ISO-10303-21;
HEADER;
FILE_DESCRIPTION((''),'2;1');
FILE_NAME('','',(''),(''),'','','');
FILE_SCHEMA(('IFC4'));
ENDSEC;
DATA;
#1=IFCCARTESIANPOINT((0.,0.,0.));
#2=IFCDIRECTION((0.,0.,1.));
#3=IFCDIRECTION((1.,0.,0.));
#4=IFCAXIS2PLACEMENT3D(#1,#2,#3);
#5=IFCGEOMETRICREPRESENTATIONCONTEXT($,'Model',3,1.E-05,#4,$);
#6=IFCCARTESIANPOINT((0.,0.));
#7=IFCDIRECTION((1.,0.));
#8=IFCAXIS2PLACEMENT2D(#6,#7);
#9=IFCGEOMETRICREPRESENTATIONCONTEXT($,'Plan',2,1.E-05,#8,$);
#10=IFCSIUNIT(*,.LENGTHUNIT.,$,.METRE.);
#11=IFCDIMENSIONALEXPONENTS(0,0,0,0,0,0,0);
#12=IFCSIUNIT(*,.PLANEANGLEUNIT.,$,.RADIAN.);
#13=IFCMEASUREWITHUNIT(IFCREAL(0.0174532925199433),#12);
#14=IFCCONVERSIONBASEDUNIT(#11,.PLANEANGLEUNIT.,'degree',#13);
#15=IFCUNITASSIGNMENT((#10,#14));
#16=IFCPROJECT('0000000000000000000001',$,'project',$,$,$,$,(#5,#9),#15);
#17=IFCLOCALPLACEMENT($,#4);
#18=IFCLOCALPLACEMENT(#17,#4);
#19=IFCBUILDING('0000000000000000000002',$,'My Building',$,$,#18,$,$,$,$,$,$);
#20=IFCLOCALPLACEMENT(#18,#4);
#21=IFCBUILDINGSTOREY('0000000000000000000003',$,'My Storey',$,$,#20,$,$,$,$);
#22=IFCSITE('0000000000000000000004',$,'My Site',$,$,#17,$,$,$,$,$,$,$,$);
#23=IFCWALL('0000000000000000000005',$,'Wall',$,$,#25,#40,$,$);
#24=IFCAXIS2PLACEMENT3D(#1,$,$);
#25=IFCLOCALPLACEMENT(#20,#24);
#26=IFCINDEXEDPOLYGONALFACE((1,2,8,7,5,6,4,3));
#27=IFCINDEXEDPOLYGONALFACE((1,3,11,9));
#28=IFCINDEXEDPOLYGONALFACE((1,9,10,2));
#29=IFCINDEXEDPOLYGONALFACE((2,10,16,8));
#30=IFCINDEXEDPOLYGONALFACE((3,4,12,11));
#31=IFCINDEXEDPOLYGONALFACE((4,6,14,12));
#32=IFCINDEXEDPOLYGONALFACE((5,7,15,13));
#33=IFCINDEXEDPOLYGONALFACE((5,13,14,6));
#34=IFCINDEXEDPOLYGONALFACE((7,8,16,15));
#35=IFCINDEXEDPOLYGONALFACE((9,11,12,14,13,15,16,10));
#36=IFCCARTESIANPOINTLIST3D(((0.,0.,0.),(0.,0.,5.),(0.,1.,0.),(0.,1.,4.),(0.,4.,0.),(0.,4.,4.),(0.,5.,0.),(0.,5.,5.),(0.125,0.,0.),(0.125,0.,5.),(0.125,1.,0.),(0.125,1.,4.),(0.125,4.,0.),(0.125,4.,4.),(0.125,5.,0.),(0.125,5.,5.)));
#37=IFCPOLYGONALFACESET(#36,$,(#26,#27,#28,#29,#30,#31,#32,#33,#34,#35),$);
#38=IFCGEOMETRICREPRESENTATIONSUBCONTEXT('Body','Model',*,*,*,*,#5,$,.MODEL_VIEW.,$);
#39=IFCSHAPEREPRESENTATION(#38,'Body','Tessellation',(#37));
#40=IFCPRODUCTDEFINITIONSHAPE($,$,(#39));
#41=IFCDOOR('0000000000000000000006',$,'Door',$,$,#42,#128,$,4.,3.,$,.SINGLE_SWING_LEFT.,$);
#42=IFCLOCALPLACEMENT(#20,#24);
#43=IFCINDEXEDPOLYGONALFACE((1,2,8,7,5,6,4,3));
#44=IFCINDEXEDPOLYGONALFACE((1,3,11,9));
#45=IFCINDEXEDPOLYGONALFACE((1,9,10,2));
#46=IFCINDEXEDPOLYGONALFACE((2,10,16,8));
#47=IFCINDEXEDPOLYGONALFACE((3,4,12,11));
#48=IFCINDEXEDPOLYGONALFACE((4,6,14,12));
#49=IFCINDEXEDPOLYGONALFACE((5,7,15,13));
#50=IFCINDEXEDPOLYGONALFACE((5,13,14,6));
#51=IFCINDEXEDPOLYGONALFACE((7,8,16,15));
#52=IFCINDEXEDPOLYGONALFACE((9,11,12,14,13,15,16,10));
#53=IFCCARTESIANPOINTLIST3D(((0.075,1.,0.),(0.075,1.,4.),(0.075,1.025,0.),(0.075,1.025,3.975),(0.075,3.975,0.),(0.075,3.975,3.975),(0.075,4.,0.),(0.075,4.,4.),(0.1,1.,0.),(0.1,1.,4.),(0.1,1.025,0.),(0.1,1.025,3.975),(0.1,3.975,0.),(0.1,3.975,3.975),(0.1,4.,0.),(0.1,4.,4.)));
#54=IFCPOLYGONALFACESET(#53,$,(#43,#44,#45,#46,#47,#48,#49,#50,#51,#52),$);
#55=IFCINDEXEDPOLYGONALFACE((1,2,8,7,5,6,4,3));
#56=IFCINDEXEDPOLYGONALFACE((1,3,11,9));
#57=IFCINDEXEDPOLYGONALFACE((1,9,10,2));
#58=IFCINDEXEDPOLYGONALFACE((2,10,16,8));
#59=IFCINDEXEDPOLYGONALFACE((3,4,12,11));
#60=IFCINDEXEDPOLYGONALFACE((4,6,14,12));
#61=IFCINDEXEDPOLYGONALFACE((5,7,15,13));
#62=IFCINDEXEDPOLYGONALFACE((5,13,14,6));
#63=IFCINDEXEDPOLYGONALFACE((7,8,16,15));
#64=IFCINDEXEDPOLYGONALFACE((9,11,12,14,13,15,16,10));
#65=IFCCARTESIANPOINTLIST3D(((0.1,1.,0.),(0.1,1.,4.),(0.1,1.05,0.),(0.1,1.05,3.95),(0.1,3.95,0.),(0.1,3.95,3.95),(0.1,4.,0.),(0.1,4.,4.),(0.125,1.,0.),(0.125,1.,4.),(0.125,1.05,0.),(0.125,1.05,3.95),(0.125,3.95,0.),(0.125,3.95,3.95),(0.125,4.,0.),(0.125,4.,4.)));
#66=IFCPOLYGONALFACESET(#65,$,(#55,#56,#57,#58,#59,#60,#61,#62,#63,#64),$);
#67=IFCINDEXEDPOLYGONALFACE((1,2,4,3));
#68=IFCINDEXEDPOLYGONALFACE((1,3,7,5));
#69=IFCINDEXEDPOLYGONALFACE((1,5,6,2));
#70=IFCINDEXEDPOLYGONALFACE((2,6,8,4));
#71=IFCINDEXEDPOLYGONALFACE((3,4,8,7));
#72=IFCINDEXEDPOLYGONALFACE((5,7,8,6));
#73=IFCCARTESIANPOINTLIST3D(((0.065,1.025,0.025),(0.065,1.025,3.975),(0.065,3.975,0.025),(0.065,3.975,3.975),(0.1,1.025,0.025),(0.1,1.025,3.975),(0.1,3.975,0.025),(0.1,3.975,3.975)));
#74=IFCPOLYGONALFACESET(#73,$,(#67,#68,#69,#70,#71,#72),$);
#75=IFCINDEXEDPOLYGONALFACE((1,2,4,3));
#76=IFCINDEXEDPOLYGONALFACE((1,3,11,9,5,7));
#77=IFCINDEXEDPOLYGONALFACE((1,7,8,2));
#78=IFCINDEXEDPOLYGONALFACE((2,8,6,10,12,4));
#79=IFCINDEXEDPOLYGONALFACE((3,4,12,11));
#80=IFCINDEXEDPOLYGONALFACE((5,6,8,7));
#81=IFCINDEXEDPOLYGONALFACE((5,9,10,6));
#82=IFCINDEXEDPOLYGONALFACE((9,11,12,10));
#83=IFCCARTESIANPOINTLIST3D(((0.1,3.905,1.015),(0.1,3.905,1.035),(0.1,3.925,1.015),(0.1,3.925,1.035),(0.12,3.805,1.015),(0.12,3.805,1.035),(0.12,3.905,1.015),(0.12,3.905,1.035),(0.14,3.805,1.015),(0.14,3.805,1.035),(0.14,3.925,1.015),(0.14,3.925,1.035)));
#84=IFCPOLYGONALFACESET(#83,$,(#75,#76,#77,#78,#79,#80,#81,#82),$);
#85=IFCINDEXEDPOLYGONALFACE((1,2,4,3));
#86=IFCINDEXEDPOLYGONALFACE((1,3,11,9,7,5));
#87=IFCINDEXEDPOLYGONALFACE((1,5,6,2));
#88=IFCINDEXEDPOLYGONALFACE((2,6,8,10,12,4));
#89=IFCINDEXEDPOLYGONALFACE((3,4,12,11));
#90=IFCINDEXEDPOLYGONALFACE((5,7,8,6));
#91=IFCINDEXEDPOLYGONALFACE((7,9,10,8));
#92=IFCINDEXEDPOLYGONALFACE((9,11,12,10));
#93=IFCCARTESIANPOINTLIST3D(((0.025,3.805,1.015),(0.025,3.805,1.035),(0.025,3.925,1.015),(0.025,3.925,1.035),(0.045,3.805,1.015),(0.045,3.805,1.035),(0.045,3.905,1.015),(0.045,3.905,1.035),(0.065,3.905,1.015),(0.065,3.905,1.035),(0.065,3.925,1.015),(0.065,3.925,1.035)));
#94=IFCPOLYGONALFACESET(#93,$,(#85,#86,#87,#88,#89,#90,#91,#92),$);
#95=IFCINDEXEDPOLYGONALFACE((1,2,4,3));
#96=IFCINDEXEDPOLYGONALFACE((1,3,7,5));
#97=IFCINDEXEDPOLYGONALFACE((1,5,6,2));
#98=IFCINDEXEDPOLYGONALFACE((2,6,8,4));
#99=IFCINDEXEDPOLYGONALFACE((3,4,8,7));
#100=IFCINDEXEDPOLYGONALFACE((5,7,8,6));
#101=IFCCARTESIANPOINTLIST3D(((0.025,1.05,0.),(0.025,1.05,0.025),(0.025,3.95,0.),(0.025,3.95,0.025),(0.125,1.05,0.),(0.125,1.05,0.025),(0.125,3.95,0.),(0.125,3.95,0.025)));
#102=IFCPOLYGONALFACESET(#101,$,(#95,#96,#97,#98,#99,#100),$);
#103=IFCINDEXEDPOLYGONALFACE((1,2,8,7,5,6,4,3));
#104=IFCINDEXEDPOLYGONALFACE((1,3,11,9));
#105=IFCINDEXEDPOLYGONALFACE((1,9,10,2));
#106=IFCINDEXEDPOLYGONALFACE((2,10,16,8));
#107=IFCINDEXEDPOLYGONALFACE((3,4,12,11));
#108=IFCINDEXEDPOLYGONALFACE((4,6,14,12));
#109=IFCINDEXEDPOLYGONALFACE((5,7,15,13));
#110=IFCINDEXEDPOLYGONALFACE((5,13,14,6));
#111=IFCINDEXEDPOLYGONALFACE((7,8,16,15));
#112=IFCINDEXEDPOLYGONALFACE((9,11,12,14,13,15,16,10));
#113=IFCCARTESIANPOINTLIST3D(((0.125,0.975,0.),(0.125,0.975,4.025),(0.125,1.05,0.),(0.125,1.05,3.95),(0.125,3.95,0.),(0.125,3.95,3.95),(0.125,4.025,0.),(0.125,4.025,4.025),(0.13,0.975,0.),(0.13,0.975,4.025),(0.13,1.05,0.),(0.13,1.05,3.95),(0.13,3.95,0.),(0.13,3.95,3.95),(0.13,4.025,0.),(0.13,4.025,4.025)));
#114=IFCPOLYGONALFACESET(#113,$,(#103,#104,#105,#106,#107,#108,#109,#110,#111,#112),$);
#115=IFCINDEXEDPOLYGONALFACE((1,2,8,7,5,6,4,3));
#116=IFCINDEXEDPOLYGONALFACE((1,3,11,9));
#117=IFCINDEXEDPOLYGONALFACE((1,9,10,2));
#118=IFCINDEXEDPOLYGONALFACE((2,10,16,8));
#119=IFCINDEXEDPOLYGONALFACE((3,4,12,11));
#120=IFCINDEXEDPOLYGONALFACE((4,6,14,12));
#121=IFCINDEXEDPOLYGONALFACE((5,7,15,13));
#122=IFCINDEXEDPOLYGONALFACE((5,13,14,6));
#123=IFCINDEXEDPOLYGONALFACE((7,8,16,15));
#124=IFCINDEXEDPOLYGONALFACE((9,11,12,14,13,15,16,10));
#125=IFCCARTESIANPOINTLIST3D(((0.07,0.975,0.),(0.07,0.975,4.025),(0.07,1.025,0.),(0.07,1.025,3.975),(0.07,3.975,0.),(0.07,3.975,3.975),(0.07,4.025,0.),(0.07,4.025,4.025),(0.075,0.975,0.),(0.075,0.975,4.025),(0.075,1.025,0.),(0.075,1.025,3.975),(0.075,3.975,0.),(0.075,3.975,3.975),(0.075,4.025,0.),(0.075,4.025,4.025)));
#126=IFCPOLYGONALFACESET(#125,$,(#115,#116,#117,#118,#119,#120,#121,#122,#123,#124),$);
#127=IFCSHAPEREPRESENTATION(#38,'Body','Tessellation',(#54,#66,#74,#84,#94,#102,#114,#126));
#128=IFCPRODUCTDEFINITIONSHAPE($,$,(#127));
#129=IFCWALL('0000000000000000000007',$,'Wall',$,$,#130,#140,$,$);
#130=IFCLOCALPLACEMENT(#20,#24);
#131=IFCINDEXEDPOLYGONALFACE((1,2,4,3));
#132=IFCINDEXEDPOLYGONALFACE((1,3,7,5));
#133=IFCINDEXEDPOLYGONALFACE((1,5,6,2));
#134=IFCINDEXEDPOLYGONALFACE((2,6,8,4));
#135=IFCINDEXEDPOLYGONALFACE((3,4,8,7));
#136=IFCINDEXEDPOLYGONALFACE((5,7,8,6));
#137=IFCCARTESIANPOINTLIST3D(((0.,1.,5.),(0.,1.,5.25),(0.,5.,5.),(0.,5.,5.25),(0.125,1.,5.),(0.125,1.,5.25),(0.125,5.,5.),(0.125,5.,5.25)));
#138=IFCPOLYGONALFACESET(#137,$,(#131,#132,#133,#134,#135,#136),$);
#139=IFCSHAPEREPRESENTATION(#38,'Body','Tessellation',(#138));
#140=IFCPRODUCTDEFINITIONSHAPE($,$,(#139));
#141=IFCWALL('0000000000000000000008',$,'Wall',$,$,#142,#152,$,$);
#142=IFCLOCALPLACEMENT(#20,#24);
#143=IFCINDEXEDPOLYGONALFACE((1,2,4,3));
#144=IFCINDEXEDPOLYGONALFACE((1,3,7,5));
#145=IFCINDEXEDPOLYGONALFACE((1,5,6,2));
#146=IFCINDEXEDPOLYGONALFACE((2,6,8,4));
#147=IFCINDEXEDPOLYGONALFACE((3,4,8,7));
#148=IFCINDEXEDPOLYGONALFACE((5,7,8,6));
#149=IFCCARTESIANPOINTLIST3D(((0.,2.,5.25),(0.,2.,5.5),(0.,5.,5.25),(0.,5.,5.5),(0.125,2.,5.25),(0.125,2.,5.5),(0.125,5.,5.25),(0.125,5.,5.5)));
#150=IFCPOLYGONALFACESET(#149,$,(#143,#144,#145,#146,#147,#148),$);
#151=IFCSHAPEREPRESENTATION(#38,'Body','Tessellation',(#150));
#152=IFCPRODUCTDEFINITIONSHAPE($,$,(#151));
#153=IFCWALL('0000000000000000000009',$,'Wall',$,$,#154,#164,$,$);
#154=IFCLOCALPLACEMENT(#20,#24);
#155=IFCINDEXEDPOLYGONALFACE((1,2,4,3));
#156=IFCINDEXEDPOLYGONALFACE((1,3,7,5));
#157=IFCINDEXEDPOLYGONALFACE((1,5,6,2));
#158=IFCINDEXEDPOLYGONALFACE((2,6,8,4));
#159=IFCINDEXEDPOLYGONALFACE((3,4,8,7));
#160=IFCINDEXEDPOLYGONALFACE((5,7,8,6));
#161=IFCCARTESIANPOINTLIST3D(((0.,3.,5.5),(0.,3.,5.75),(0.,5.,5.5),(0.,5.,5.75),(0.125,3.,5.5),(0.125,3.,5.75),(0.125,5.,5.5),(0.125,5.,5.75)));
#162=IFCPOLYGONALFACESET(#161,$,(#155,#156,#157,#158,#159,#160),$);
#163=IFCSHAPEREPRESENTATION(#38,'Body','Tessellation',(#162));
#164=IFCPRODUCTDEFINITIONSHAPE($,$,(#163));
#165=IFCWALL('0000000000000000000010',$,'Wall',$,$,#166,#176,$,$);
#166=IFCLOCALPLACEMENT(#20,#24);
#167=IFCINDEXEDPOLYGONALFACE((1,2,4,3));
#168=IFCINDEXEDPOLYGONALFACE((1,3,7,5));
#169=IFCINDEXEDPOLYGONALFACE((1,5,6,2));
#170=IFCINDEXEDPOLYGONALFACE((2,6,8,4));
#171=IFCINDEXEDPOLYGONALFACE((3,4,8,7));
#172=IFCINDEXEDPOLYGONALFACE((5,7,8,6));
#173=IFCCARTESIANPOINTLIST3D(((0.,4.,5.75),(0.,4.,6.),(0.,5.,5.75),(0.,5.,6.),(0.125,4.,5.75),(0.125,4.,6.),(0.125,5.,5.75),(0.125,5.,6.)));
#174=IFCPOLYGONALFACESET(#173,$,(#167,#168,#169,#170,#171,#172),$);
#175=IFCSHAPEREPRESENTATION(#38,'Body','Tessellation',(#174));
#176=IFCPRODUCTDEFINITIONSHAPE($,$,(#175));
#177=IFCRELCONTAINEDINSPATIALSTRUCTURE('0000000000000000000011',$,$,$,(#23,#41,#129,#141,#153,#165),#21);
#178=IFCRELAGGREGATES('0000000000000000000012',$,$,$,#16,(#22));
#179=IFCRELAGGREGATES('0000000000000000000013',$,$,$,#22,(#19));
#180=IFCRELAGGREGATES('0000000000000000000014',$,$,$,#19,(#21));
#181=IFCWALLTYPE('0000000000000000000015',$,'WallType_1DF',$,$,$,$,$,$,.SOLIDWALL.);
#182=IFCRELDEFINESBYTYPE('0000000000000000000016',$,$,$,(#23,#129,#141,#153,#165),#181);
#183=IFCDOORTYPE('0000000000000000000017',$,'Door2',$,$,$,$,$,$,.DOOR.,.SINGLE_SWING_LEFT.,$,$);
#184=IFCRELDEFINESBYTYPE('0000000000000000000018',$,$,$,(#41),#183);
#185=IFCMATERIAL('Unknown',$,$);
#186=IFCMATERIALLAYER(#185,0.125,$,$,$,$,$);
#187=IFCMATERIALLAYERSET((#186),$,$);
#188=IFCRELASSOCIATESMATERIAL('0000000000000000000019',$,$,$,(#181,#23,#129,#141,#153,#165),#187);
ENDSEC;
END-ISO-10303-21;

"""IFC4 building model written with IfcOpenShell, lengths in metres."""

from ifc_helpers import new_model, entity, si_unit, converted_unit, frame, origin_with_axes, origin_2d_with_axis, place, context, subcontext, project, spatial, line, indexed_curve, outline, extrude, shape, source, transform, mapped, material, layer, layer_set, layer_usage, type_object, type_shapes, element, fill, save


model = new_model("IFC4")

# Units and contexts
model_context = context("Model", 3, precision=1e-05, world=origin_with_axes())
plan_context = context("Plan", 2, precision=1e-05, world=origin_2d_with_axis())
body_context_1 = subcontext(model_context, "Body", "Model", "MODEL_VIEW")
body_context_2 = subcontext(plan_context, "Body", "Plan", "PLAN_VIEW")
ifc_project = project(units=[si_unit("LENGTHUNIT", "METRE"), converted_unit("PLANEANGLEUNIT", "degree", entity("IfcReal", 0.0174532925199433), si_unit("PLANEANGLEUNIT", "RADIAN"), dimensions=[0, 0, 0, 0, 0, 0, 0])], contexts=[model_context, plan_context])

# Site, building, storey
site_placement = place(None, origin_with_axes())
site = spatial("IfcSite", under=ifc_project, at=site_placement, Name="My Site")
building_placement = place(site_placement, origin_with_axes())
building = spatial("IfcBuilding", under=site, at=building_placement, Name="My Building")
storey_placement = place(building_placement, origin_with_axes())
storey = spatial("IfcBuildingStorey", under=building, at=storey_placement, Name="My Storey")

# Wall, opening, door
ifc_material = material(Name="Unknown")
ifc_layer = layer(ifc_material, 0.125)
ifc_layer_set = layer_set([ifc_layer])
ifc_layer_usage_1 = layer_usage(ifc_layer_set, "AXIS2", "POSITIVE", 0.0)
wall_type = type_object("IfcWallType", Name="WallType_1DF", PredefinedType="SOLIDWALL", material=ifc_layer_set)
wall_1_placement = place(storey_placement, frame((0.125, 0.0, 0.0), z_axis=(0.0, 0.0, 1.0), x_axis=(0.0, 1.0, 0.0)))
wall_1 = element("IfcWall", 1, at=wall_1_placement, inside=storey, type_object=wall_type, material=ifc_layer_usage_1, Name="Wall", context=body_context_1, shape_type="SweptSolid", body=[
    extrude(outline(indexed_curve([(0.0, 0.0), (0.0, 0.125), (5.0, 0.125), (5.0, 0.0), (0.0, 0.0)], self_intersect=False)), origin_with_axes(), (0.0, 0.0, 1.0), 5.0),
])
shared_shape_1 = source(origin_with_axes(), body_context_1, "Body", "SweptSolid", [
    extrude(outline(indexed_curve([(0.0, 0.0), (3.0, 0.0), (3.0, 4.0), (0.0, 4.0)], segments=[line(1, 2, 3, 4, 1)])), frame((0.0, -0.1, 0.0), z_axis=(0.0, -1.0, 0.0), x_axis=(1.0, 0.0, 0.0)), (0.0, 0.0, -1.0), 0.45),
])
opening_1_placement = place(wall_1_placement, frame((1.0, 0.0, 0.0), z_axis=(0.0, 0.0, 1.0), x_axis=(1.0, 0.0, 0.0)))
opening_1 = element("IfcOpeningElement", 2, at=opening_1_placement, cuts=wall_1, PredefinedType="OPENING", context=body_context_1, shape_type="MappedRepresentation", body=[
    mapped(shared_shape_1, transform((0.0, 0.0, 0.0), x_axis=(1.0, 0.0, 0.0), y_axis=(0.0, 1.0, 0.0), z_axis=(0.0, 0.0, 1.0), scale=1.0)),
])
door_type = type_object("IfcDoorType", Name="Door2", OperationType="SINGLE_SWING_LEFT", PredefinedType="DOOR")
shared_shape_2 = source(origin_with_axes(), body_context_1, "Body", "SweptSolid", [
    extrude(outline(indexed_curve([(0.0, 0.0), (0.0, 4.0), (3.0, 4.0), (3.0, 0.0), (2.975, 0.0), (2.975, 3.975), (0.025, 3.975), (0.025, 0.0)], segments=[line(1, 2, 3, 4, 5, 6, 7, 8, 1)])), frame((0.0, 0.025, 0.0), z_axis=(0.0, -1.0, 0.0), x_axis=(1.0, 0.0, 0.0)), (0.0, 0.0, -1.0), 0.025),
    extrude(outline(indexed_curve([(0.0, 0.0), (0.0, 4.0), (3.0, 4.0), (3.0, 0.0), (2.95, 0.0), (2.95, 3.95), (0.05, 3.95), (0.05, 0.0)], segments=[line(1, 2, 3, 4, 5, 6, 7, 8, 1)])), frame((0.0, 0.0, 0.0), z_axis=(0.0, -1.0, 0.0), x_axis=(1.0, 0.0, 0.0)), (0.0, 0.0, -1.0), 0.025),
    extrude(outline(indexed_curve([(0.0, 0.0), (2.95, 0.0), (2.95, 0.035), (0.0, 0.035)], segments=[line(1, 2, 3, 4, 1)])), frame((0.025, 0.025, 0.025), z_axis=(0.0, 0.0, 1.0), x_axis=(1.0, 0.0, 0.0)), (0.0, 0.0, 1.0), 3.95),
    extrude(outline(indexed_curve([(0.0, 0.0), (0.0, -0.04), (-0.12, -0.04), (-0.12, -0.02), (-0.02, -0.02), (-0.02, 0.0)], segments=[line(1, 2, 3, 4, 5, 6, 1)])), frame((2.925, 0.025, 1.015), z_axis=(0.0, 0.0, 1.0), x_axis=(1.0, 0.0, 0.0)), (0.0, 0.0, 1.0), 0.02),
    extrude(outline(indexed_curve([(0.0, 0.0), (0.0, 0.04), (-0.12, 0.04), (-0.12, 0.02), (-0.02, 0.02), (-0.02, 0.0)], segments=[line(1, 2, 3, 4, 5, 6, 1)])), frame((2.925, 0.06, 1.015), z_axis=(0.0, 0.0, 1.0), x_axis=(1.0, 0.0, 0.0)), (0.0, 0.0, 1.0), 0.02),
    extrude(outline(indexed_curve([(0.0, 0.0), (2.9, 0.0), (2.9, 0.1), (0.0, 0.1)], segments=[line(1, 2, 3, 4, 1)])), frame((0.05, 0.0, 0.0), z_axis=(0.0, 0.0, 1.0), x_axis=(1.0, 0.0, 0.0)), (0.0, 0.0, 1.0), 0.025),
    extrude(outline(indexed_curve([(0.0, 0.0), (0.0, 4.025), (3.05, 4.025), (3.05, 0.0), (2.975, 0.0), (2.975, 3.95), (0.075, 3.95), (0.075, 0.0)], segments=[line(1, 2, 3, 4, 5, 6, 7, 8, 1)])), frame((-0.025, -0.005, 0.0), z_axis=(0.0, -1.0, 0.0), x_axis=(1.0, 0.0, 0.0)), (0.0, 0.0, -1.0), 0.005),
    extrude(outline(indexed_curve([(0.0, 0.0), (0.0, 4.025), (3.05, 4.025), (3.05, 0.0), (3.0, 0.0), (3.0, 3.975), (0.05, 3.975), (0.05, 0.0)], segments=[line(1, 2, 3, 4, 5, 6, 7, 8, 1)])), frame((-0.025, 0.05, 0.0), z_axis=(0.0, -1.0, 0.0), x_axis=(1.0, 0.0, 0.0)), (0.0, 0.0, -1.0), 0.005),
])
shared_shape_3 = source(origin_with_axes(), body_context_2, "Body", "Curve2D", [
    entity("IfcIndexedPolyCurve", entity("IfcCartesianPointList2D", [[0.0, 0.0], [0.0, 0.05], [0.025, 0.05], [0.025, 0.025], [0.05, 0.025], [0.05, 0.0]]), [entity("IfcLineIndex", [1, 2, 3, 4, 5, 6, 1])]),
    entity("IfcIndexedPolyCurve", entity("IfcCartesianPointList2D", [[3.0, 0.0], [3.0, 0.05], [2.975, 0.05], [2.975, 0.025], [2.95, 0.025], [2.95, 0.0]]), [entity("IfcLineIndex", [1, 2, 3, 4, 5, 6, 1])]),
    entity("IfcTrimmedCurve", entity("IfcEllipse", entity("IfcAxis2Placement2D", entity("IfcCartesianPoint", [0.06, 0.05]), entity("IfcDirection", [1.0, 0.0])), 2.915, 2.95), [entity("IfcCartesianPoint", [2.975, 0.05])], [entity("IfcCartesianPoint", [0.06, 3.0])], True, "CARTESIAN"),
    entity("IfcIndexedPolyCurve", entity("IfcCartesianPointList2D", [[0.025, 0.05], [0.06, 0.05], [0.06, 3.0], [0.025, 3.0]]), [entity("IfcLineIndex", [1, 2, 3, 4, 1])]),
])
type_shapes(door_type, [shared_shape_2, shared_shape_3])
door_placement = place(opening_1_placement, origin_with_axes())
door = element("IfcDoor", 3, at=door_placement, inside=storey, type_object=door_type, Name="Door", OperationType="SINGLE_SWING_LEFT", OverallHeight=4.0, OverallWidth=3.0, shapes=[
    shape(body_context_1, "Body", "MappedRepresentation", [mapped(shared_shape_2, transform((0.0, 0.0, 0.0), x_axis=(1.0, 0.0, 0.0), y_axis=(0.0, 1.0, 0.0), z_axis=(0.0, 0.0, 1.0), scale=1.0))]),
    shape(body_context_2, "Body", "MappedRepresentation", [mapped(shared_shape_3, transform((0.0, 0.0, 0.0), x_axis=(1.0, 0.0, 0.0), y_axis=(0.0, 1.0, 0.0), z_axis=(0.0, 0.0, 1.0), scale=1.0))]),
])
fill(opening_1, door)

# Walls
ifc_layer_usage_2 = layer_usage(ifc_layer_set, "AXIS2", "POSITIVE", 0.0)
wall_2_placement = place(storey_placement, frame((0.125, 1.0, 5.0), z_axis=(0.0, 0.0, 1.0), x_axis=(0.0, 1.0, 0.0)))
element("IfcWall", 4, at=wall_2_placement, inside=storey, type_object=wall_type, material=ifc_layer_usage_2, Name="Wall", context=body_context_1, shape_type="SweptSolid", body=[
    extrude(outline(indexed_curve([(0.0, 0.0), (0.0, 0.125), (4.0, 0.125), (4.0, 0.0), (0.0, 0.0)], self_intersect=False)), origin_with_axes(), (0.0, 0.0, 1.0), 0.25),
])
ifc_layer_usage_3 = layer_usage(ifc_layer_set, "AXIS2", "POSITIVE", 0.0)
wall_3_placement = place(storey_placement, frame((0.125, 2.0, 5.25), z_axis=(0.0, 0.0, 1.0), x_axis=(0.0, 1.0, 0.0)))
element("IfcWall", 5, at=wall_3_placement, inside=storey, type_object=wall_type, material=ifc_layer_usage_3, Name="Wall", context=body_context_1, shape_type="SweptSolid", body=[
    extrude(outline(indexed_curve([(0.0, 0.0), (0.0, 0.125), (3.0, 0.125), (3.0, 0.0), (0.0, 0.0)], self_intersect=False)), origin_with_axes(), (0.0, 0.0, 1.0), 0.25),
])
ifc_layer_usage_4 = layer_usage(ifc_layer_set, "AXIS2", "POSITIVE", 0.0)
wall_4_placement = place(storey_placement, frame((0.125, 3.0, 5.5), z_axis=(0.0, 0.0, 1.0), x_axis=(0.0, 1.0, 0.0)))
element("IfcWall", 6, at=wall_4_placement, inside=storey, type_object=wall_type, material=ifc_layer_usage_4, Name="Wall", context=body_context_1, shape_type="SweptSolid", body=[
    extrude(outline(indexed_curve([(0.0, 0.0), (0.0, 0.125), (2.0, 0.125), (2.0, 0.0), (0.0, 0.0)], self_intersect=False)), origin_with_axes(), (0.0, 0.0, 1.0), 0.25),
])
ifc_layer_usage_5 = layer_usage(ifc_layer_set, "AXIS2", "POSITIVE", 0.0)
wall_5_placement = place(storey_placement, frame((0.125, 4.0, 5.75), z_axis=(0.0, 0.0, 1.0), x_axis=(0.0, 1.0, 0.0)))
element("IfcWall", 7, at=wall_5_placement, inside=storey, type_object=wall_type, material=ifc_layer_usage_5, Name="Wall", context=body_context_1, shape_type="SweptSolid", body=[
    extrude(outline(indexed_curve([(0.0, 0.0), (0.0, 0.125), (1.0, 0.125), (1.0, 0.0), (0.0, 0.0)], self_intersect=False)), origin_with_axes(), (0.0, 0.0, 1.0), 0.25),
])

save(model, "model.ifc")
